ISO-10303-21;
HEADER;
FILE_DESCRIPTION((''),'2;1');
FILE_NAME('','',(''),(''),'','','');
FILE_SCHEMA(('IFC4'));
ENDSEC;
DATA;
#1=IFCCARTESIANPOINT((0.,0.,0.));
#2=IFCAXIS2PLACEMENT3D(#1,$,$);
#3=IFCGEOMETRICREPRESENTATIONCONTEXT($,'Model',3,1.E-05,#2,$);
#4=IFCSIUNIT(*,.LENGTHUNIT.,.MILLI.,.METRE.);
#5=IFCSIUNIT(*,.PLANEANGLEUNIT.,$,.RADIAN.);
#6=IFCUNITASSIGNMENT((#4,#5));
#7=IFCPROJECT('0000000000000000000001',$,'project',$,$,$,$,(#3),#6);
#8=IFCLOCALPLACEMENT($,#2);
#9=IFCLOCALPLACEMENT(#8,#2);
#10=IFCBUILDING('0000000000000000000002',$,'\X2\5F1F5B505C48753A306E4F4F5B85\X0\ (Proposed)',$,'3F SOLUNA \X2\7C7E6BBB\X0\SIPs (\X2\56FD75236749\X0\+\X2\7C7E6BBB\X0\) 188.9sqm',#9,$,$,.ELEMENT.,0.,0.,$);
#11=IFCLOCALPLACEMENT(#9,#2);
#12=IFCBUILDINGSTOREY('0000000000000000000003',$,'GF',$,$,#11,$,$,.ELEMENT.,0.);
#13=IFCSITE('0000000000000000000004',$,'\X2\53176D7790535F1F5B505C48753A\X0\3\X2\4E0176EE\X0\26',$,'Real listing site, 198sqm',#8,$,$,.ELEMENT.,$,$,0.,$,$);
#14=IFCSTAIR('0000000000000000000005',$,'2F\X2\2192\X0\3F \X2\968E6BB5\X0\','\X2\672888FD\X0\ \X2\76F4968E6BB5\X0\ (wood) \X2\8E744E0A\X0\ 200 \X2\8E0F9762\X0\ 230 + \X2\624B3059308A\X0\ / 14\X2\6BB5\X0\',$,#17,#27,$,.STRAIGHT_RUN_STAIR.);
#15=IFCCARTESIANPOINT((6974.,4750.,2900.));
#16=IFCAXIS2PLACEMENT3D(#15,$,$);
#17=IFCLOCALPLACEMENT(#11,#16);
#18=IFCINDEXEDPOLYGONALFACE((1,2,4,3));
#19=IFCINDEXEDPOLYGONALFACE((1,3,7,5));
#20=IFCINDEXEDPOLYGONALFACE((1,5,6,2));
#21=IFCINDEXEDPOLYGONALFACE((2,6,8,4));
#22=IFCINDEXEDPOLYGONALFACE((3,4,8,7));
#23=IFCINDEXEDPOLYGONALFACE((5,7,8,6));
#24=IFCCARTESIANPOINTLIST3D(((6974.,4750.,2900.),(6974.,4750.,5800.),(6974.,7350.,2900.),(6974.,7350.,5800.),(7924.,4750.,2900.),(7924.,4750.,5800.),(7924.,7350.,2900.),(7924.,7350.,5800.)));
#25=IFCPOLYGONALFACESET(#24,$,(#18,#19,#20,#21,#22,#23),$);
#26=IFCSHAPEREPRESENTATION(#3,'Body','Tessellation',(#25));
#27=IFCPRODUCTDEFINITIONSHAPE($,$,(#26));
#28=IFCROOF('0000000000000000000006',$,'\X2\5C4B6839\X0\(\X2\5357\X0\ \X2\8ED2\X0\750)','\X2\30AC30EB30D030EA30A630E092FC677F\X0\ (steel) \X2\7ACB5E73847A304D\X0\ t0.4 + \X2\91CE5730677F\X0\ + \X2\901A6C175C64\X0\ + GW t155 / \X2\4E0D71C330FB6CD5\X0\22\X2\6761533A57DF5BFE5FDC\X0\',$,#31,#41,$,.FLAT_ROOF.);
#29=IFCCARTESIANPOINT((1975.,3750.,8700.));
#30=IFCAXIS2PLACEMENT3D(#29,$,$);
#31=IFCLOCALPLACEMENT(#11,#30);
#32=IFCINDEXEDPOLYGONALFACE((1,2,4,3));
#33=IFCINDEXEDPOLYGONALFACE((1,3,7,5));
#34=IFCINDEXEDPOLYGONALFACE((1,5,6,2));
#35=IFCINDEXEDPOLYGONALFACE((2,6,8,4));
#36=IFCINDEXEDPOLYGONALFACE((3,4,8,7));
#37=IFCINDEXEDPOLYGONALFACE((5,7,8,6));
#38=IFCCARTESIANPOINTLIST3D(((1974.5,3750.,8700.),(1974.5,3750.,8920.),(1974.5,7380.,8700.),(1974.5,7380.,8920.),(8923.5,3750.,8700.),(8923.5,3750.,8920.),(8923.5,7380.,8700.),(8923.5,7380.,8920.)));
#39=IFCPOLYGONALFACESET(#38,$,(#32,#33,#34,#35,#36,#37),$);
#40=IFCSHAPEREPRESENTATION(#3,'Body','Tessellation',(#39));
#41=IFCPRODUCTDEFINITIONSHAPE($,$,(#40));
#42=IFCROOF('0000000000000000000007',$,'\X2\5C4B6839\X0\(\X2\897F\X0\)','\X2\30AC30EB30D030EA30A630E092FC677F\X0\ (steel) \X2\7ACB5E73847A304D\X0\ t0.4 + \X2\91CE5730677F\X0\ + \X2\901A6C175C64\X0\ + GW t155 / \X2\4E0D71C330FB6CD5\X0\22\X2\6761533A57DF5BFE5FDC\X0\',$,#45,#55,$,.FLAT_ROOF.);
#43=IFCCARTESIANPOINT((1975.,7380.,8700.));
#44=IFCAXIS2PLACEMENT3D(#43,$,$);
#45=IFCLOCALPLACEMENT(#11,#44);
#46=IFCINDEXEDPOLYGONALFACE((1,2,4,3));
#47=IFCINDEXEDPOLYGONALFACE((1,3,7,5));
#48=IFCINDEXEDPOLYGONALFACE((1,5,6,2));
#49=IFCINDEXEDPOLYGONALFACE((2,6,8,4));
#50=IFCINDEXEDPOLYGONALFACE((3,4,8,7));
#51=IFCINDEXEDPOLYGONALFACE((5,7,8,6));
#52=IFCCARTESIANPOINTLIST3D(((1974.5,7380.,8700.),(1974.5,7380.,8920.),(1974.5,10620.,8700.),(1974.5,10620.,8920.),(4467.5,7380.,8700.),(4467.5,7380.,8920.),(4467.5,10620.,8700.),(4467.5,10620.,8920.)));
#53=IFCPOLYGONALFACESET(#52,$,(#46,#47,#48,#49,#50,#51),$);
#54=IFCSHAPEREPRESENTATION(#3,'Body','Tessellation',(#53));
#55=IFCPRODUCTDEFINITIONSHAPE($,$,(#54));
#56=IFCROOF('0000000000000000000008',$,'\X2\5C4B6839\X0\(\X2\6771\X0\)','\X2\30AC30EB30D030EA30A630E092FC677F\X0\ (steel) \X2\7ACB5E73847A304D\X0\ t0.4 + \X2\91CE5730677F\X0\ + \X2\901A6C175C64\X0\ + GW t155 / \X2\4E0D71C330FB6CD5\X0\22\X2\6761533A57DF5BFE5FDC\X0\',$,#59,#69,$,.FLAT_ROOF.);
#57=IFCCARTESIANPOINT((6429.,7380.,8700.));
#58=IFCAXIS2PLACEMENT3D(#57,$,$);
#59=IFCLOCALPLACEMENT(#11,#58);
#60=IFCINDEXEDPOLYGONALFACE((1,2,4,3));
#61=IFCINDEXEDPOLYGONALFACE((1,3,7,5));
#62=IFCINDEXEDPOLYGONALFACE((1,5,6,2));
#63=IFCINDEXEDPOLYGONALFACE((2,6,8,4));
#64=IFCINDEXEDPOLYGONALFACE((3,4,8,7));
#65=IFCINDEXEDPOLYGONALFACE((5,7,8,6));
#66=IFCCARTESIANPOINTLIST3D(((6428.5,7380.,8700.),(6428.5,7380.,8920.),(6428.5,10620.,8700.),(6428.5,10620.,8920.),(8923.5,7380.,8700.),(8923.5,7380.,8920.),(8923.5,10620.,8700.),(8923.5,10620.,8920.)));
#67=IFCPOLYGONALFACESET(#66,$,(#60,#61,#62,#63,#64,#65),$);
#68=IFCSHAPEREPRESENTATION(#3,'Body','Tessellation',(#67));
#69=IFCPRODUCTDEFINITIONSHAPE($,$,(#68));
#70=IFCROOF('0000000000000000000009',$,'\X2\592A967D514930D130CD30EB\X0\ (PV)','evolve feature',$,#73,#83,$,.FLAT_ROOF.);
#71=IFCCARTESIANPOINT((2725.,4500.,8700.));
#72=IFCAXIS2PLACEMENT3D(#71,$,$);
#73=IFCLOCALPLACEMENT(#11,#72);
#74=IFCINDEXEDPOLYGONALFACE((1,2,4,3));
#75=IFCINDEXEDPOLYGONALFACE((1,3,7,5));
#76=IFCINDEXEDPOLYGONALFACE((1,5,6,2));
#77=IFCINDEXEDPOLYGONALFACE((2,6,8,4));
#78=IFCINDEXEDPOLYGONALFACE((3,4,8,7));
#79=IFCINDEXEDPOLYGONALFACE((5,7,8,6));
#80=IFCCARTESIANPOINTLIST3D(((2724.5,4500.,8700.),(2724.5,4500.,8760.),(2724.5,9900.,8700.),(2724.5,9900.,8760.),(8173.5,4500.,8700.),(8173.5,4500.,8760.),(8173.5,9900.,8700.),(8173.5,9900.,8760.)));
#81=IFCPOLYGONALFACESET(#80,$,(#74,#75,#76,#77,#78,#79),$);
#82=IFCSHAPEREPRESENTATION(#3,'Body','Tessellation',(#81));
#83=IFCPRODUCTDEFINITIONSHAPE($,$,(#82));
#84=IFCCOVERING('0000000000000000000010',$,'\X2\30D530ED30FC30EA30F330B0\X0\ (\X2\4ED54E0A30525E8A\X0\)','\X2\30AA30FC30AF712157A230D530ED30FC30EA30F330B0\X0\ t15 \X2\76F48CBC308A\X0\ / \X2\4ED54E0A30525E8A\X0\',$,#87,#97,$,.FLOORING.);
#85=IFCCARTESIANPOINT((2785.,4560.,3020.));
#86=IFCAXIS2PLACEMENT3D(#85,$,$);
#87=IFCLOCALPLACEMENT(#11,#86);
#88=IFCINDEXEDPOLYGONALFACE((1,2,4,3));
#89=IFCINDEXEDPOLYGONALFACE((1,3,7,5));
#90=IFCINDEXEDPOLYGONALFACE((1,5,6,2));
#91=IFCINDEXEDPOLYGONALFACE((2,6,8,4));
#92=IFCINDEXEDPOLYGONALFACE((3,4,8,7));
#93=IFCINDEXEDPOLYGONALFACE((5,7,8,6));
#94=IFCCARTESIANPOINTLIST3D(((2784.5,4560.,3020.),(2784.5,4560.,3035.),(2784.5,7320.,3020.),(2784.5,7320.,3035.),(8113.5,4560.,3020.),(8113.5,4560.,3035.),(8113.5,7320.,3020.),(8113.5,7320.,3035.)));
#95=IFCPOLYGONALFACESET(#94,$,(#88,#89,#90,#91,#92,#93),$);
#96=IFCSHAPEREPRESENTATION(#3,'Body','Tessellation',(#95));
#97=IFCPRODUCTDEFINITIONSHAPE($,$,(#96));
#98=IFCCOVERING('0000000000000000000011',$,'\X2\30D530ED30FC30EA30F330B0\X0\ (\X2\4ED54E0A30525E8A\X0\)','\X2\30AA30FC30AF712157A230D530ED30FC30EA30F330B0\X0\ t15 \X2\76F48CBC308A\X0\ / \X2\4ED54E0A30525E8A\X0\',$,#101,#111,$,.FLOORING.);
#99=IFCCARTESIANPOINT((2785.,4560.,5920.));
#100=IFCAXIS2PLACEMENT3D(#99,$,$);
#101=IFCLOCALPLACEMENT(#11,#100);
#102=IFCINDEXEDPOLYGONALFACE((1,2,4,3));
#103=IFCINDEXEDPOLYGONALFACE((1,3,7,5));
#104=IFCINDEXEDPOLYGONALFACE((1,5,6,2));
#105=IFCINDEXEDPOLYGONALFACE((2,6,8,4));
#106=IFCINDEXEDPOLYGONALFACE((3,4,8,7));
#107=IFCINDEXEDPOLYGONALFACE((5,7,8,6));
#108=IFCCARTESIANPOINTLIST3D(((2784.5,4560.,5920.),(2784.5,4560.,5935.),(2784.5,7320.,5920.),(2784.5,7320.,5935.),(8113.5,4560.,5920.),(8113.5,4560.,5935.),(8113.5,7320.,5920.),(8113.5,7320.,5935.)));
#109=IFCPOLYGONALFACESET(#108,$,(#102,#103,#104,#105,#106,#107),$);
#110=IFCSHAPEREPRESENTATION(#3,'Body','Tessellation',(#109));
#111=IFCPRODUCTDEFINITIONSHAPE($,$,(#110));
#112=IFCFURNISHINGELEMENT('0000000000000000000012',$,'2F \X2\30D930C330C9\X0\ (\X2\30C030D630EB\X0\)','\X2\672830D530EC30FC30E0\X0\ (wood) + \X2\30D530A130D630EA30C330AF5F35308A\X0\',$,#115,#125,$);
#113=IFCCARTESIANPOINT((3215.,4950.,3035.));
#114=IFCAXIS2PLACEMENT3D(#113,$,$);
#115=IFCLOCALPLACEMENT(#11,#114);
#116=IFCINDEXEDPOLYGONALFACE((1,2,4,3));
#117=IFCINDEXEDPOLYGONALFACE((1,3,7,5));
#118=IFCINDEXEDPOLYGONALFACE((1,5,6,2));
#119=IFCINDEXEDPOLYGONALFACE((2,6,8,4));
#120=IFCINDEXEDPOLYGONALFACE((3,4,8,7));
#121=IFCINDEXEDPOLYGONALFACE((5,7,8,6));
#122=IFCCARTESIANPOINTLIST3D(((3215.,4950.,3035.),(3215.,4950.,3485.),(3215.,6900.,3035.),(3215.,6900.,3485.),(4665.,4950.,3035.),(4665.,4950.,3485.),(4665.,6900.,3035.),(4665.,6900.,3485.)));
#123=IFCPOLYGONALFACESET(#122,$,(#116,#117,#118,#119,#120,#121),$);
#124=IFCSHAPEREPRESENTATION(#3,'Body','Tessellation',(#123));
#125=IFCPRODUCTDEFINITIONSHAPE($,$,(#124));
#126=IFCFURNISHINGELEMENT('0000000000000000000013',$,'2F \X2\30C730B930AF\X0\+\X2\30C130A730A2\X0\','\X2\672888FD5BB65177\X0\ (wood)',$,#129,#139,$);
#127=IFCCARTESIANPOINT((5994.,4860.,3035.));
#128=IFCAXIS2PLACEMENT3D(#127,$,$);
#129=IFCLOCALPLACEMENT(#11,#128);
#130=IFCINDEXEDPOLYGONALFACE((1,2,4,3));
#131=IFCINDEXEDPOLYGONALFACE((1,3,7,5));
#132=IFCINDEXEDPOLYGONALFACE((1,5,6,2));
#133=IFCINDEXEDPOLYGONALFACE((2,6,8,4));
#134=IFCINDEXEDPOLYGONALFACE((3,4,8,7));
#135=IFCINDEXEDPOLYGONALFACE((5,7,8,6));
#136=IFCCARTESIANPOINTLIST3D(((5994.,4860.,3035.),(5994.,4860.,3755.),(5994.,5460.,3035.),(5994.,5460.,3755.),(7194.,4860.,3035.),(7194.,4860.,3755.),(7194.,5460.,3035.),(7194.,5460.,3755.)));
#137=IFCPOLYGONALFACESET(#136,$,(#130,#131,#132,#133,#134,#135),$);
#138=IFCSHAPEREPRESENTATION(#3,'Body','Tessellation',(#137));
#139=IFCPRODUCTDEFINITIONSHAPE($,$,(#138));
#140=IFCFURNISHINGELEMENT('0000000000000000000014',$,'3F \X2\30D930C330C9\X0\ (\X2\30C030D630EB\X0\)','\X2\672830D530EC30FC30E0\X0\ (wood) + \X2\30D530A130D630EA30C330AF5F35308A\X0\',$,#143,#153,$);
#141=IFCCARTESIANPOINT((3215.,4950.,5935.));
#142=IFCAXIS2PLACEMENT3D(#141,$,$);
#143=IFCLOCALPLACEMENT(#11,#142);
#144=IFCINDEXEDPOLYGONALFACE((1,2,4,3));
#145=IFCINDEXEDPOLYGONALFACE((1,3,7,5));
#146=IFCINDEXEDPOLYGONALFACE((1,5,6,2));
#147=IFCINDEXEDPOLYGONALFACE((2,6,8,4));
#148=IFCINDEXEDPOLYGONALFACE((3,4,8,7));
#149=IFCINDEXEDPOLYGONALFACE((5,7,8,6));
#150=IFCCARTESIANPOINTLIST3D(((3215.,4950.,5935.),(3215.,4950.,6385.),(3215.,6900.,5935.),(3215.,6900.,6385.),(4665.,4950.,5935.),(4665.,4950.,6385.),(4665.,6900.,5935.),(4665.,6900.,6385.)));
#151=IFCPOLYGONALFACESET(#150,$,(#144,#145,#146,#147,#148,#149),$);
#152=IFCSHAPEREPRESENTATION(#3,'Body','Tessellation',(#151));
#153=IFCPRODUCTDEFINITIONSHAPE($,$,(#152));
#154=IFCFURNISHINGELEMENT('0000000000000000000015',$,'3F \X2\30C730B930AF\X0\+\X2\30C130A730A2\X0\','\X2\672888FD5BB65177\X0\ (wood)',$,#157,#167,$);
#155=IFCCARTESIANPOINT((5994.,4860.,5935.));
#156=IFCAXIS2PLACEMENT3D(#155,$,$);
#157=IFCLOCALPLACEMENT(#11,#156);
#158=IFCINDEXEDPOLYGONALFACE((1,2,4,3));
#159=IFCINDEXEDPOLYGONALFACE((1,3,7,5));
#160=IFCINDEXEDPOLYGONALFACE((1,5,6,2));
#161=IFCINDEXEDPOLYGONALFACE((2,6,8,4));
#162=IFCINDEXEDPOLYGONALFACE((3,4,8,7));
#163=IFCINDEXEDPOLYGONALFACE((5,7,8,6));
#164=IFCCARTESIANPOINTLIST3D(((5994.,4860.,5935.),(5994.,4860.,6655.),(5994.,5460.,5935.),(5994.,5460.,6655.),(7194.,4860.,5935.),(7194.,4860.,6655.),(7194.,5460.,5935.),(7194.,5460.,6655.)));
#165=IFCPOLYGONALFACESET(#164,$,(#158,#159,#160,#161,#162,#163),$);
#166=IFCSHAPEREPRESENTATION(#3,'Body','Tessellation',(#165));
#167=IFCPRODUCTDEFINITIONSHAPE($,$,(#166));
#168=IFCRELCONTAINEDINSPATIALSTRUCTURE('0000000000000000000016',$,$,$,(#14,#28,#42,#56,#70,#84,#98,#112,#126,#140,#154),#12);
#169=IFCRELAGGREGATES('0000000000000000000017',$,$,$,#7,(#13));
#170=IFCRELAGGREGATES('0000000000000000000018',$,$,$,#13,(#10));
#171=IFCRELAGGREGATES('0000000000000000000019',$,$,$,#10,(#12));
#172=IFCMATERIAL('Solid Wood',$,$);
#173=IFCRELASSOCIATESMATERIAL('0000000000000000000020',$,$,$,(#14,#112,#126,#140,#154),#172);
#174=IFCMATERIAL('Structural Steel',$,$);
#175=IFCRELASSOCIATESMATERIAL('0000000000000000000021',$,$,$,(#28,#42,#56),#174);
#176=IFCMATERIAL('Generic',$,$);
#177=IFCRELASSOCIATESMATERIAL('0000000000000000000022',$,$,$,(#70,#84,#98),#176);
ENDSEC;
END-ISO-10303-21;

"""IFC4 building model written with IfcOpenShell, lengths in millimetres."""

from ifc_helpers import new_model, si_unit, frame, frame_2d, origin, place, context, project, spatial, rectangle, extrude, material, element, save


model = new_model("IFC4")

# Units and contexts
model_context = context("Model", 3, precision=1e-05, world=origin())
ifc_project = project(units=[si_unit("LENGTHUNIT", "METRE", prefix="MILLI"), si_unit("PLANEANGLEUNIT", "RADIAN")], contexts=[model_context])

# Site, building, storey
site_placement = place(None, origin())
site = spatial("IfcSite", under=ifc_project, at=site_placement, Name="北海道弟子屈町3丁目26", ObjectType="Real listing site, 198sqm", CompositionType="ELEMENT", RefElevation=0.0)
building_placement = place(site_placement, origin())
building = spatial("IfcBuilding", under=site, at=building_placement, Name="弟子屈町の住宅 (Proposed)", ObjectType="3F SOLUNA 籾殻SIPs (国産杉+籾殻) 188.9sqm", CompositionType="ELEMENT", ElevationOfRefHeight=0.0, ElevationOfTerrain=0.0)
storey_placement = place(building_placement, origin())
storey = spatial("IfcBuildingStorey", under=building, at=storey_placement, Name="GF", CompositionType="ELEMENT", Elevation=0.0)

# Shared definitions
ifc_material_1 = material(Name="Solid Wood")

# Stair
stair_placement = place(storey_placement, frame((6974.0, 4750.0, 2900.0)))
element("IfcStair", 1, at=stair_placement, inside=storey, material=ifc_material_1, Name="2F→3F 階段", Description="木製 直階段 (wood) 蹴上 200 踏面 230 + 手すり / 14段", PredefinedType="STRAIGHT_RUN_STAIR", context=model_context, shape_type="SweptSolid", body=[
    extrude(rectangle(XDim=950.0, YDim=2600.0, at=frame_2d((475.0, 1300.0))), frame((6974.0, 4750.0, 2900.0)), (0.0, 0.0, 1.0), 2900.0),
])

# Roofs
ifc_material_2 = material(Name="Structural Steel")
roof_1_placement = place(storey_placement, frame((1975.0, 3750.0, 8700.0)))
element("IfcRoof", 2, at=roof_1_placement, inside=storey, material=ifc_material_2, Name="屋根(南 軒750)", Description="ガルバリウム鋼板 (steel) 立平葺き t0.4 + 野地板 + 通気層 + GW t155 / 不燃・法22条区域対応", PredefinedType="FLAT_ROOF", context=model_context, shape_type="SweptSolid", body=[
    extrude(rectangle(XDim=6949.0, YDim=3630.0, at=frame_2d((3474.0, 1815.0))), frame((1975.0, 3750.0, 8700.0)), (0.0, 0.0, 1.0), 220.0),
])
roof_2_placement = place(storey_placement, frame((1975.0, 7380.0, 8700.0)))
element("IfcRoof", 3, at=roof_2_placement, inside=storey, material=ifc_material_2, Name="屋根(西)", Description="ガルバリウム鋼板 (steel) 立平葺き t0.4 + 野地板 + 通気層 + GW t155 / 不燃・法22条区域対応", PredefinedType="FLAT_ROOF", context=model_context, shape_type="SweptSolid", body=[
    extrude(rectangle(XDim=2493.0, YDim=3240.0, at=frame_2d((1246.0, 1620.0))), frame((1975.0, 7380.0, 8700.0)), (0.0, 0.0, 1.0), 220.0),
])
roof_3_placement = place(storey_placement, frame((6429.0, 7380.0, 8700.0)))
element("IfcRoof", 4, at=roof_3_placement, inside=storey, material=ifc_material_2, Name="屋根(東)", Description="ガルバリウム鋼板 (steel) 立平葺き t0.4 + 野地板 + 通気層 + GW t155 / 不燃・法22条区域対応", PredefinedType="FLAT_ROOF", context=model_context, shape_type="SweptSolid", body=[
    extrude(rectangle(XDim=2495.0, YDim=3240.0, at=frame_2d((1247.0, 1620.0))), frame((6429.0, 7380.0, 8700.0)), (0.0, 0.0, 1.0), 220.0),
])
ifc_material_3 = material(Name="Generic")
roof_4_placement = place(storey_placement, frame((2725.0, 4500.0, 8700.0)))
element("IfcRoof", 5, at=roof_4_placement, inside=storey, material=ifc_material_3, Name="太陽光パネル (PV)", Description="evolve feature", PredefinedType="FLAT_ROOF", context=model_context, shape_type="SweptSolid", body=[
    extrude(rectangle(XDim=5449.0, YDim=5400.0, at=frame_2d((2724.0, 2700.0))), frame((2725.0, 4500.0, 8700.0)), (0.0, 0.0, 1.0), 60.0),
])

# Coverings
covering_1_placement = place(storey_placement, frame((2785.0, 4560.0, 3020.0)))
element("IfcCovering", 6, at=covering_1_placement, inside=storey, material=ifc_material_3, Name="フローリング (仕上げ床)", Description="オーク無垢フローリング t15 直貼り / 仕上げ床", PredefinedType="FLOORING", context=model_context, shape_type="SweptSolid", body=[
    extrude(rectangle(XDim=5329.0, YDim=2760.0, at=frame_2d((2664.0, 1380.0))), frame((2785.0, 4560.0, 3020.0)), (0.0, 0.0, 1.0), 15.0),
])
covering_2_placement = place(storey_placement, frame((2785.0, 4560.0, 5920.0)))
element("IfcCovering", 7, at=covering_2_placement, inside=storey, material=ifc_material_3, Name="フローリング (仕上げ床)", Description="オーク無垢フローリング t15 直貼り / 仕上げ床", PredefinedType="FLOORING", context=model_context, shape_type="SweptSolid", body=[
    extrude(rectangle(XDim=5329.0, YDim=2760.0, at=frame_2d((2664.0, 1380.0))), frame((2785.0, 4560.0, 5920.0)), (0.0, 0.0, 1.0), 15.0),
])

# Furnishing elements
furnishing_1_placement = place(storey_placement, frame((3215.0, 4950.0, 3035.0)))
element("IfcFurnishingElement", 8, at=furnishing_1_placement, inside=storey, material=ifc_material_1, Name="2F ベッド (ダブル)", Description="木フレーム (wood) + ファブリック張り", context=model_context, shape_type="SweptSolid", body=[
    extrude(rectangle(XDim=1450.0, YDim=1950.0, at=frame_2d((725.0, 975.0))), frame((3215.0, 4950.0, 3035.0)), (0.0, 0.0, 1.0), 450.0),
])
furnishing_2_placement = place(storey_placement, frame((5994.0, 4860.0, 3035.0)))
element("IfcFurnishingElement", 9, at=furnishing_2_placement, inside=storey, material=ifc_material_1, Name="2F デスク+チェア", Description="木製家具 (wood)", context=model_context, shape_type="SweptSolid", body=[
    extrude(rectangle(XDim=1200.0, YDim=600.0, at=frame_2d((600.0, 300.0))), frame((5994.0, 4860.0, 3035.0)), (0.0, 0.0, 1.0), 720.0),
])
furnishing_3_placement = place(storey_placement, frame((3215.0, 4950.0, 5935.0)))
element("IfcFurnishingElement", 10, at=furnishing_3_placement, inside=storey, material=ifc_material_1, Name="3F ベッド (ダブル)", Description="木フレーム (wood) + ファブリック張り", context=model_context, shape_type="SweptSolid", body=[
    extrude(rectangle(XDim=1450.0, YDim=1950.0, at=frame_2d((725.0, 975.0))), frame((3215.0, 4950.0, 5935.0)), (0.0, 0.0, 1.0), 450.0),
])
furnishing_4_placement = place(storey_placement, frame((5994.0, 4860.0, 5935.0)))
element("IfcFurnishingElement", 11, at=furnishing_4_placement, inside=storey, material=ifc_material_1, Name="3F デスク+チェア", Description="木製家具 (wood)", context=model_context, shape_type="SweptSolid", body=[
    extrude(rectangle(XDim=1200.0, YDim=600.0, at=frame_2d((600.0, 300.0))), frame((5994.0, 4860.0, 5935.0)), (0.0, 0.0, 1.0), 720.0),
])

save(model, "model.ifc")
